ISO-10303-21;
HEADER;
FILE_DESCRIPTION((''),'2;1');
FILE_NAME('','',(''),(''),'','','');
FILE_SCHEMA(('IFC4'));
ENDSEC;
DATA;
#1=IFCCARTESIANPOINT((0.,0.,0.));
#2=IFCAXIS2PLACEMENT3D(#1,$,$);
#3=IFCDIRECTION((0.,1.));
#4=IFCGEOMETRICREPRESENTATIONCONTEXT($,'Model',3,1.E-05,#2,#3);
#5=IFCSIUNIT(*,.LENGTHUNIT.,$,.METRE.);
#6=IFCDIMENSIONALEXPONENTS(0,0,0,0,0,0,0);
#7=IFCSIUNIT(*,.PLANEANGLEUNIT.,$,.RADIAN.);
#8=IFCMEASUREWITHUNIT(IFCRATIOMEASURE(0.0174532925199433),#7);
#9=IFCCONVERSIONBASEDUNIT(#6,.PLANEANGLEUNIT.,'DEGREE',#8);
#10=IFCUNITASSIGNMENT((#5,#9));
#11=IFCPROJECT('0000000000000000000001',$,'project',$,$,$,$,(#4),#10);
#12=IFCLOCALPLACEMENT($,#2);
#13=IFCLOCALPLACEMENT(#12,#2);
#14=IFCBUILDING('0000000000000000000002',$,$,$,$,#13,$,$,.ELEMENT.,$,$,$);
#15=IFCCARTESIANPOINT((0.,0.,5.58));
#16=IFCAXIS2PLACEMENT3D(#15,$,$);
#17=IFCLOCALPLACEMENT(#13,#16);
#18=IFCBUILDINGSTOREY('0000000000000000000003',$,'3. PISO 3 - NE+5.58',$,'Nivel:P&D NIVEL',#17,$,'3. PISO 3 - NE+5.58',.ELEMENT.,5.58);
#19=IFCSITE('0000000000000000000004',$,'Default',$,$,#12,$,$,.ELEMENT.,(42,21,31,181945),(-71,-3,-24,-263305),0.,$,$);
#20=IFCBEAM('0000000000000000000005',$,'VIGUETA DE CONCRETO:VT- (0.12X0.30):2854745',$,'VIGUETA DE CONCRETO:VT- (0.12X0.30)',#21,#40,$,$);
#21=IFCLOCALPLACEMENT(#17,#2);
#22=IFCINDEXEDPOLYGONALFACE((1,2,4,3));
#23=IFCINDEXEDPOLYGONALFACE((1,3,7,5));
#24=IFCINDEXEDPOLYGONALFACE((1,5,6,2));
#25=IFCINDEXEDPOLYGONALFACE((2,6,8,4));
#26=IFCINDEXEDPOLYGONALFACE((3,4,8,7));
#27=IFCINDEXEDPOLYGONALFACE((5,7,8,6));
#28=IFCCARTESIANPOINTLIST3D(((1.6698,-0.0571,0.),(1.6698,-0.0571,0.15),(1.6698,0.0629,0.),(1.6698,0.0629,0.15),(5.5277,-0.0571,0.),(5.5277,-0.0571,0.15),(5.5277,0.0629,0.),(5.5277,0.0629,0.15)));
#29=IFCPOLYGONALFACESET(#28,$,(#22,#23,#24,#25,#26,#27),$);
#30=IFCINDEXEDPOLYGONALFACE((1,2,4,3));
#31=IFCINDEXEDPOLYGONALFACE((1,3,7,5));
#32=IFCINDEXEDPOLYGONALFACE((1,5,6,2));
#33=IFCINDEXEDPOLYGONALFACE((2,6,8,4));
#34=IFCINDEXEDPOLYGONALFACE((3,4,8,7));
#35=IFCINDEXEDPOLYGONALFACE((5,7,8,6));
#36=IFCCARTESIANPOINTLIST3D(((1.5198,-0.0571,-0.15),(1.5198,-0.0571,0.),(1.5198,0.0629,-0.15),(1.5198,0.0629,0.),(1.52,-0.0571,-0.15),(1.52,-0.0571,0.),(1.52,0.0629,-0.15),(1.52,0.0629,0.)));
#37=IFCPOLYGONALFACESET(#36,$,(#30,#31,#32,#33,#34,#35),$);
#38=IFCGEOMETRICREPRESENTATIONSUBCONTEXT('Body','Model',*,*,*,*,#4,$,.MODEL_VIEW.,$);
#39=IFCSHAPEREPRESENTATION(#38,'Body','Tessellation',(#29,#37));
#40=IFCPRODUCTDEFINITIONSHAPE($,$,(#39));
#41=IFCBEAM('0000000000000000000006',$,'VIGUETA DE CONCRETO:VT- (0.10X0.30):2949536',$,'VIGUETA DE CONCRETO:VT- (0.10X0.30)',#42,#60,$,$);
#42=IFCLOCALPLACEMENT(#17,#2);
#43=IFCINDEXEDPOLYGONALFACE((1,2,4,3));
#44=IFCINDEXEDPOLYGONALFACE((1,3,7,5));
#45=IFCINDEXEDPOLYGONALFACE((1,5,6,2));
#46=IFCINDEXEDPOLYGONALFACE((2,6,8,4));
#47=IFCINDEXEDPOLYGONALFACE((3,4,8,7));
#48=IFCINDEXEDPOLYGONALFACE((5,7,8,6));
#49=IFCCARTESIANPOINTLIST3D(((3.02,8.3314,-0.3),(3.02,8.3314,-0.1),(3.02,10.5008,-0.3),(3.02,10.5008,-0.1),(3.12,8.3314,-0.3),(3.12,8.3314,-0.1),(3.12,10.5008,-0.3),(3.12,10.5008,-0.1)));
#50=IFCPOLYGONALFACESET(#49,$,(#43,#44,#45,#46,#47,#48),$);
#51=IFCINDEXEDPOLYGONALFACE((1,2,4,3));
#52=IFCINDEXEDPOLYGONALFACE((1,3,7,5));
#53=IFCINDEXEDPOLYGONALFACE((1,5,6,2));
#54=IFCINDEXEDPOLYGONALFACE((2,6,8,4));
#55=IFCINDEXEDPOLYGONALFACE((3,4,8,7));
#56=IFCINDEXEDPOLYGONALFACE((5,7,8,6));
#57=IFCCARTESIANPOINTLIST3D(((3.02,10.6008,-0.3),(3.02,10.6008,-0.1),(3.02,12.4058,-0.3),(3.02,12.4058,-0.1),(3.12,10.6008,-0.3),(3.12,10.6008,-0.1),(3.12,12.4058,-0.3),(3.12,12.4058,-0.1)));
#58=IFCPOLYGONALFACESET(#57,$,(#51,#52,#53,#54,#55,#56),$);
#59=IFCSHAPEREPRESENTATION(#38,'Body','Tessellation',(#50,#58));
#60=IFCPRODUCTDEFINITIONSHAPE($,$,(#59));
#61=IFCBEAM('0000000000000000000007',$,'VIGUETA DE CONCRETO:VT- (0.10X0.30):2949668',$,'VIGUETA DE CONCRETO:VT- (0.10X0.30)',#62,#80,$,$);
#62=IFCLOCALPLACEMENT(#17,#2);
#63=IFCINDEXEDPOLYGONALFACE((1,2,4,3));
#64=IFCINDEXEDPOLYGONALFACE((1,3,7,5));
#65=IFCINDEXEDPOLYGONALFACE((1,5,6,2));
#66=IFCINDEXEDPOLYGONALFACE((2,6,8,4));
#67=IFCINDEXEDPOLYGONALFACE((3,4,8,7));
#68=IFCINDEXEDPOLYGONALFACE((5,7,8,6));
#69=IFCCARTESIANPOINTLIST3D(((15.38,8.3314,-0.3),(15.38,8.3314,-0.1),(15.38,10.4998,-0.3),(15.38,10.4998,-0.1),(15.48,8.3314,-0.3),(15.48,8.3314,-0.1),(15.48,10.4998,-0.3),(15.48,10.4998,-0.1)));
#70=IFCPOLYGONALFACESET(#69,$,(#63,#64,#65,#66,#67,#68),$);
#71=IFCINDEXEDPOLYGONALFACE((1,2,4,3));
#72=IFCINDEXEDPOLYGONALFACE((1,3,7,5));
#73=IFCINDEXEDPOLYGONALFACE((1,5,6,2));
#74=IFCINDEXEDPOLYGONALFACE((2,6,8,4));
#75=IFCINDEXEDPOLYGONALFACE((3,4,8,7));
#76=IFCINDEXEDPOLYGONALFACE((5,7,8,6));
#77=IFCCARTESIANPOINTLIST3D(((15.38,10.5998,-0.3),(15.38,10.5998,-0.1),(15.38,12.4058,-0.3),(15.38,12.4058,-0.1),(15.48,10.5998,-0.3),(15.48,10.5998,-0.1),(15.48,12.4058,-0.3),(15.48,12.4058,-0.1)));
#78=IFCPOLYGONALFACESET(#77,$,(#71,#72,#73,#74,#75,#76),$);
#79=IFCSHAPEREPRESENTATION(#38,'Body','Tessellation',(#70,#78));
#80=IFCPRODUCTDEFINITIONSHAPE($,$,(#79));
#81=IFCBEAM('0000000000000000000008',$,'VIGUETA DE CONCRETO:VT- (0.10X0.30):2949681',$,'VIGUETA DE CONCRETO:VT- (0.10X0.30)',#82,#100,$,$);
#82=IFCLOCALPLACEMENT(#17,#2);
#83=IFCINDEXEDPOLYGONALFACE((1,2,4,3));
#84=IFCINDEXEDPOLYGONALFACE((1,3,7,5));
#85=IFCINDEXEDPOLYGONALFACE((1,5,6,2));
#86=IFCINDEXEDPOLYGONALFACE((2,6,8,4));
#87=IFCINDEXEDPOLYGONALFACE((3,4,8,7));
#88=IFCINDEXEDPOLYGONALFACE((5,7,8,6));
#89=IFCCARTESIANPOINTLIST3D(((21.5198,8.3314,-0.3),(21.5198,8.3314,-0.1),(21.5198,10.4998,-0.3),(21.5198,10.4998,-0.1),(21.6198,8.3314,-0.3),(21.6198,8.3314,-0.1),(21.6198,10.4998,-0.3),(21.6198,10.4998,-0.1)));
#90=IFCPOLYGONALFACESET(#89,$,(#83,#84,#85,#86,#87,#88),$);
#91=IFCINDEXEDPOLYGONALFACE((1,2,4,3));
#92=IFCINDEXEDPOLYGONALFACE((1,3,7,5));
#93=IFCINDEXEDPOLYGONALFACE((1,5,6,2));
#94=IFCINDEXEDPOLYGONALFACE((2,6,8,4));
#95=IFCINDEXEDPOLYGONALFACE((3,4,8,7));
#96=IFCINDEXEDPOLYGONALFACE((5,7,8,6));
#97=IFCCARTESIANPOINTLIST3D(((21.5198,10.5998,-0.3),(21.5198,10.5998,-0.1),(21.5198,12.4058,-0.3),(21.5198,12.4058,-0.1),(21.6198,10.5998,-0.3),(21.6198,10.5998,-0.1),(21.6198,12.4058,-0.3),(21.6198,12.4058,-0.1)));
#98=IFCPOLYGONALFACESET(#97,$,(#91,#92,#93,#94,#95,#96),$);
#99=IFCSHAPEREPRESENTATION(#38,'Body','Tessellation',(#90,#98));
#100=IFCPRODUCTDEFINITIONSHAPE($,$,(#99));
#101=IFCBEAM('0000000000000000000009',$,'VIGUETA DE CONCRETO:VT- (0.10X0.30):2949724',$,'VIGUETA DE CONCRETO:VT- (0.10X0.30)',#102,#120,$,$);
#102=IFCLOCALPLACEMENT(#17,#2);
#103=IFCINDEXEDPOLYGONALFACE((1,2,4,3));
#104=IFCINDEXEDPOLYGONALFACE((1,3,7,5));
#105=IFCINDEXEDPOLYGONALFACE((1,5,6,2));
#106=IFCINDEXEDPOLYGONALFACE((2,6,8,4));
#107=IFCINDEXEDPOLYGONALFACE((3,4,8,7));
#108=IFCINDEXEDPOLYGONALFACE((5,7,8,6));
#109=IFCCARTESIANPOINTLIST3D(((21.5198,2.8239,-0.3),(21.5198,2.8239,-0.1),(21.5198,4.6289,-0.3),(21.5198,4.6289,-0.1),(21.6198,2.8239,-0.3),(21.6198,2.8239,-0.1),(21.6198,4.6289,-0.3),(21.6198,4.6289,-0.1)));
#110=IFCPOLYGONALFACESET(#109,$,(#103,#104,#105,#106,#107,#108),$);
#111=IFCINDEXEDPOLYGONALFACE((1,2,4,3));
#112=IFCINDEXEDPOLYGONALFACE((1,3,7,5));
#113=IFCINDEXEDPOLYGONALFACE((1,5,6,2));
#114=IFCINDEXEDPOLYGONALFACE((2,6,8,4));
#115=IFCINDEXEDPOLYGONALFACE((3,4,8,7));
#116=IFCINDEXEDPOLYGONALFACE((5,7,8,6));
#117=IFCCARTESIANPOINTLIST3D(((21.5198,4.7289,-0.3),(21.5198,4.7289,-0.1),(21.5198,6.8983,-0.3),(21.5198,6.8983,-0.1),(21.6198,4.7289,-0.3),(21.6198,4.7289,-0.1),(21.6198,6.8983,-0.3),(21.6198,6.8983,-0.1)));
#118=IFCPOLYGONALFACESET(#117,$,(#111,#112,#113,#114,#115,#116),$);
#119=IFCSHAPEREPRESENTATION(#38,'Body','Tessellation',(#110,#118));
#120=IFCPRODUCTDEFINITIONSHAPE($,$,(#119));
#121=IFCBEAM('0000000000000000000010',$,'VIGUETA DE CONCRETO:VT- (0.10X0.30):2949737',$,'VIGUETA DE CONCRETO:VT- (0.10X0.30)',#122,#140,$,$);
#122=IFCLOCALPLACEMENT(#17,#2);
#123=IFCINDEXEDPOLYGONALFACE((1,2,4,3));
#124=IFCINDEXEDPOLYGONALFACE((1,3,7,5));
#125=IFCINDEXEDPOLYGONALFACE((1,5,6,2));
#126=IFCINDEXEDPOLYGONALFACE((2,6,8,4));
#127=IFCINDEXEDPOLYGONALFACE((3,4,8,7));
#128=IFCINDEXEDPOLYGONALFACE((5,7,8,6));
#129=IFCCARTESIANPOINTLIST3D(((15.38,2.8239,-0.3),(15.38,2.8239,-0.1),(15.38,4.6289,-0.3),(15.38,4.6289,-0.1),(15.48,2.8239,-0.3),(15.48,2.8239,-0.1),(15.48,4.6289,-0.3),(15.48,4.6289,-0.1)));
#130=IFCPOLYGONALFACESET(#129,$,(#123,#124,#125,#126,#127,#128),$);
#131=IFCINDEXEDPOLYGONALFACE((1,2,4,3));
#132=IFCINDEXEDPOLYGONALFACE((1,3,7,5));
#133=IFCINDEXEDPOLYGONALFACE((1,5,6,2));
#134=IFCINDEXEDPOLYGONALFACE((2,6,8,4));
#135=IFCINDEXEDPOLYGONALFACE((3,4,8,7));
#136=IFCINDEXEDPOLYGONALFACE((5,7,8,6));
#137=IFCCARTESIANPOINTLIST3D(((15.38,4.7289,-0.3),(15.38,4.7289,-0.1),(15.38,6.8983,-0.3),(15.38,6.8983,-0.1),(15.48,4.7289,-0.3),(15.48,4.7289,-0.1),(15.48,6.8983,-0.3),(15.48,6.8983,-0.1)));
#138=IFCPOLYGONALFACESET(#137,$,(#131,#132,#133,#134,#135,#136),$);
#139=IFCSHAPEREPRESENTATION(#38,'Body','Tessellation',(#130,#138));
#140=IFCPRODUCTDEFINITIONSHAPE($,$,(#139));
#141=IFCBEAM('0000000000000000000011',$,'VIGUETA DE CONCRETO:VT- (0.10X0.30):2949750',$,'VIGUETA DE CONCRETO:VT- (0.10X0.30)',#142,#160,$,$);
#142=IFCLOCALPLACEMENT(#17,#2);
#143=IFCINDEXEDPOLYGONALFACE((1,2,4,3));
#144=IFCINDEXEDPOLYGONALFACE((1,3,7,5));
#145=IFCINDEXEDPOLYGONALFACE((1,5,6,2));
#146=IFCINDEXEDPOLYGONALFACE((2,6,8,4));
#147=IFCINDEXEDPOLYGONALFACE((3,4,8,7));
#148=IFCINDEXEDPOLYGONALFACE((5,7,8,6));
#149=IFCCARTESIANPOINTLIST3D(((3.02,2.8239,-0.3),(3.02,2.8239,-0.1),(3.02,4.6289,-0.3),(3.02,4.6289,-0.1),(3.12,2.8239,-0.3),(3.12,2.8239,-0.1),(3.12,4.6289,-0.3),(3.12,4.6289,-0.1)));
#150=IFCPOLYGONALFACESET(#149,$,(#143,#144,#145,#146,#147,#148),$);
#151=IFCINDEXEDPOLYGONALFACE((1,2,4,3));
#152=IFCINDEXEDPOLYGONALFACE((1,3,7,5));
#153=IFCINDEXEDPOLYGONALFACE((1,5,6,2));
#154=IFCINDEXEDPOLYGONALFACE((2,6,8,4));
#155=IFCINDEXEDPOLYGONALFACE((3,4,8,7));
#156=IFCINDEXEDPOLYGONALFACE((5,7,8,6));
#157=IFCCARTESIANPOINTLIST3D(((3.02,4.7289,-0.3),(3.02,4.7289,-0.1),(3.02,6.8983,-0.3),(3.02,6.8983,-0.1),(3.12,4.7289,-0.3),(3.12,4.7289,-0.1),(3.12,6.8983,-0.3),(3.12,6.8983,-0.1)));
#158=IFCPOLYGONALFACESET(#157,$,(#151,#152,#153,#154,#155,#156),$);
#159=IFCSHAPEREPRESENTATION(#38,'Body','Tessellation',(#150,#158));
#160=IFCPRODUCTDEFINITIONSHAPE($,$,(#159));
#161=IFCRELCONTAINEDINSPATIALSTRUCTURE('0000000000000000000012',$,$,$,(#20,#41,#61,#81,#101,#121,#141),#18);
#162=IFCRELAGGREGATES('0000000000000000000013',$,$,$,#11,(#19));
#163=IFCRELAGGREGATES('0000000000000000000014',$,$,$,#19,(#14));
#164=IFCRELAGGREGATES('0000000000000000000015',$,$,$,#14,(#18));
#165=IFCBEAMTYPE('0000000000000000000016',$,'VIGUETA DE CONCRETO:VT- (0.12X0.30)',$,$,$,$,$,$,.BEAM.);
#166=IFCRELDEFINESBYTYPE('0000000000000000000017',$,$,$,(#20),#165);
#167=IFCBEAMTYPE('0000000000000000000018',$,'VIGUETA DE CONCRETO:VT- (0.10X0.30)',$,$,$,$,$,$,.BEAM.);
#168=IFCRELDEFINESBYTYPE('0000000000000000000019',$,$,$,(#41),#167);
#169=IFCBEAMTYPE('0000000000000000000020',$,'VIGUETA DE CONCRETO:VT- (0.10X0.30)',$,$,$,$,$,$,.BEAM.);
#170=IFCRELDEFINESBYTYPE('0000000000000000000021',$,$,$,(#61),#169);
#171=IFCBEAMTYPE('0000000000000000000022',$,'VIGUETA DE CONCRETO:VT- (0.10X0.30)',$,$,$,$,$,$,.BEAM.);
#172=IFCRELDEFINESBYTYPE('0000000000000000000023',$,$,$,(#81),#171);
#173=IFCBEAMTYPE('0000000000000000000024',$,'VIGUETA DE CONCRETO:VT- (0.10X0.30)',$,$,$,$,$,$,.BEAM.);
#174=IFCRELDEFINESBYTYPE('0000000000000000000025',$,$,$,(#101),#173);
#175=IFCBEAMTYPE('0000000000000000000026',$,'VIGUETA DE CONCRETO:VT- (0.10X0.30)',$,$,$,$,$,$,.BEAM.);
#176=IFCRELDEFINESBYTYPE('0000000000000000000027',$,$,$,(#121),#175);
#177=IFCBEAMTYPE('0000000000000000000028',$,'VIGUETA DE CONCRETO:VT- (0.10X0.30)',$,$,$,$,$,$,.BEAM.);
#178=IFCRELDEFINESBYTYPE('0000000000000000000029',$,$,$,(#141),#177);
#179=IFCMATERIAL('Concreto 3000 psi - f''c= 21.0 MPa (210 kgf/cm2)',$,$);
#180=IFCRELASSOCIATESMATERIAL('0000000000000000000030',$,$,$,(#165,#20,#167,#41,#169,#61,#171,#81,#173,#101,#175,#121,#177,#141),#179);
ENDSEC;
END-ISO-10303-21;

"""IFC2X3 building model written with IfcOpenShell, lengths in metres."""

from ifc_helpers import new_model, entity, si_unit, converted_unit, direction, frame, frame_2d, origin, place, context, subcontext, project, spatial, rectangle, extrude, source, transform, mapped, material, type_object, type_shapes, element, save


model = new_model("IFC2X3")

# Units and contexts
model_context = context("Model", 3, precision=1e-05, world=origin(), true_north=direction((0.0, 1.0)))
body_context = subcontext(model_context, "Body", "Model", "MODEL_VIEW")
ifc_project = project(units=[si_unit("LENGTHUNIT", "METRE"), converted_unit("PLANEANGLEUNIT", "DEGREE", entity("IfcRatioMeasure", 0.0174532925199433), si_unit("PLANEANGLEUNIT", "RADIAN"), dimensions=[0, 0, 0, 0, 0, 0, 0])], contexts=[model_context])

# Site, building, storey
site_placement = place(None, origin())
site = spatial("IfcSite", under=ifc_project, at=site_placement, Name="Default", CompositionType="ELEMENT", RefLatitude=(42, 21, 31, 181945), RefLongitude=(-71, -3, -24, -263305), RefElevation=0.0)
building_placement = place(site_placement, origin())
building = spatial("IfcBuilding", under=site, at=building_placement, CompositionType="ELEMENT")
storey_placement = place(building_placement, frame((0.0, 0.0, 5.58)))
storey = spatial("IfcBuildingStorey", under=building, at=storey_placement, Name="3. PISO 3 - NE+5.58", ObjectType="Nivel:P&D NIVEL", LongName="3. PISO 3 - NE+5.58", CompositionType="ELEMENT", Elevation=5.58)

# Beams
ifc_material = material(Name="Concreto 3000 psi - f'c= 21.0 MPa (210 kgf/cm2)")
beam_type_1 = type_object("IfcBeamType", Name="VIGUETA DE CONCRETO:VT- (0.12X0.30)", PredefinedType="BEAM", material=ifc_material)
shared_shape_1 = source(origin(), body_context, "Body", "SweptSolid", [
    extrude(rectangle(XDim=0.15, YDim=0.12, at=frame_2d((0.0, 0.0), x_axis=(1.0, 0.0))), frame((1.6698, 0.0029, 5.655), z_axis=(1.0, 0.0, 0.0), x_axis=(0.0, 0.0, -1.0)), (0.0, 0.0, 1.0), 3.8579),
    extrude(rectangle(XDim=0.15, YDim=0.12, at=frame_2d((0.0, 0.0), x_axis=(1.0, 0.0))), frame((1.5198, 0.0029, 5.505), z_axis=(1.0, 0.0, 0.0), x_axis=(0.0, 0.0, -1.0)), (0.0, 0.0, 1.0), 0.0002),
])
type_shapes(beam_type_1, [shared_shape_1])
beam_1_placement = place(storey_placement, frame((0.0, 0.0, -5.58)))
element("IfcBeam", 1, at=beam_1_placement, inside=storey, type_object=beam_type_1, material=ifc_material, Name="VIGUETA DE CONCRETO:VT- (0.12X0.30):2854745", ObjectType="VIGUETA DE CONCRETO:VT- (0.12X0.30)", context=body_context, shape_type="MappedRepresentation", body=[
    mapped(shared_shape_1, transform((0.0, 0.0, 0.0), scale=1.0)),
])
beam_type_2 = type_object("IfcBeamType", Name="VIGUETA DE CONCRETO:VT- (0.10X0.30)", PredefinedType="BEAM", material=ifc_material)
shared_shape_2 = source(origin(), body_context, "Body", "SweptSolid", [
    extrude(rectangle(XDim=0.2, YDim=0.1, at=frame_2d((0.0, 0.0), x_axis=(0.0, 1.0))), frame((3.07, 10.5008, 5.38), z_axis=(0.0, -1.0, 0.0), x_axis=(-1.0, 0.0, 0.0)), (0.0, 0.0, 1.0), 2.1694),
    extrude(rectangle(XDim=0.2, YDim=0.1, at=frame_2d((0.0, 0.0), x_axis=(0.0, 1.0))), frame((3.07, 12.4058, 5.38), z_axis=(0.0, -1.0, 0.0), x_axis=(-1.0, 0.0, 0.0)), (0.0, 0.0, 1.0), 1.805),
])
type_shapes(beam_type_2, [shared_shape_2])
beam_2_placement = place(storey_placement, frame((0.0, 0.0, -5.58)))
element("IfcBeam", 2, at=beam_2_placement, inside=storey, type_object=beam_type_2, material=ifc_material, Name="VIGUETA DE CONCRETO:VT- (0.10X0.30):2949536", ObjectType="VIGUETA DE CONCRETO:VT- (0.10X0.30)", context=body_context, shape_type="MappedRepresentation", body=[
    mapped(shared_shape_2, transform((0.0, 0.0, 0.0), scale=1.0)),
])
beam_type_3 = type_object("IfcBeamType", Name="VIGUETA DE CONCRETO:VT- (0.10X0.30)", PredefinedType="BEAM", material=ifc_material)
shared_shape_3 = source(origin(), body_context, "Body", "SweptSolid", [
    extrude(rectangle(XDim=0.2, YDim=0.1, at=frame_2d((0.0, 0.0), x_axis=(0.0, 1.0))), frame((15.43, 10.4998, 5.38), z_axis=(0.0, -1.0, 0.0), x_axis=(-1.0, 0.0, 0.0)), (0.0, 0.0, 1.0), 2.1684),
    extrude(rectangle(XDim=0.2, YDim=0.1, at=frame_2d((0.0, 0.0), x_axis=(0.0, 1.0))), frame((15.43, 12.4058, 5.38), z_axis=(0.0, -1.0, 0.0), x_axis=(-1.0, 0.0, 0.0)), (0.0, 0.0, 1.0), 1.806),
])
type_shapes(beam_type_3, [shared_shape_3])
beam_3_placement = place(storey_placement, frame((0.0, 0.0, -5.58)))
element("IfcBeam", 3, at=beam_3_placement, inside=storey, type_object=beam_type_3, material=ifc_material, Name="VIGUETA DE CONCRETO:VT- (0.10X0.30):2949668", ObjectType="VIGUETA DE CONCRETO:VT- (0.10X0.30)", context=body_context, shape_type="MappedRepresentation", body=[
    mapped(shared_shape_3, transform((0.0, 0.0, 0.0), scale=1.0)),
])
beam_type_4 = type_object("IfcBeamType", Name="VIGUETA DE CONCRETO:VT- (0.10X0.30)", PredefinedType="BEAM", material=ifc_material)
shared_shape_4 = source(origin(), body_context, "Body", "SweptSolid", [
    extrude(rectangle(XDim=0.2, YDim=0.1, at=frame_2d((0.0, 0.0), x_axis=(0.0, 1.0))), frame((21.5698, 10.4998, 5.38), z_axis=(0.0, -1.0, 0.0), x_axis=(-1.0, 0.0, 0.0)), (0.0, 0.0, 1.0), 2.1684),
    extrude(rectangle(XDim=0.2, YDim=0.1, at=frame_2d((0.0, 0.0), x_axis=(0.0, 1.0))), frame((21.5698, 12.4058, 5.38), z_axis=(0.0, -1.0, 0.0), x_axis=(-1.0, 0.0, 0.0)), (0.0, 0.0, 1.0), 1.806),
])
type_shapes(beam_type_4, [shared_shape_4])
beam_4_placement = place(storey_placement, frame((0.0, 0.0, -5.58)))
element("IfcBeam", 4, at=beam_4_placement, inside=storey, type_object=beam_type_4, material=ifc_material, Name="VIGUETA DE CONCRETO:VT- (0.10X0.30):2949681", ObjectType="VIGUETA DE CONCRETO:VT- (0.10X0.30)", context=body_context, shape_type="MappedRepresentation", body=[
    mapped(shared_shape_4, transform((0.0, 0.0, 0.0), scale=1.0)),
])
beam_type_5 = type_object("IfcBeamType", Name="VIGUETA DE CONCRETO:VT- (0.10X0.30)", PredefinedType="BEAM", material=ifc_material)
shared_shape_5 = source(origin(), body_context, "Body", "SweptSolid", [
    extrude(rectangle(XDim=0.2, YDim=0.1, at=frame_2d((0.0, 0.0), x_axis=(0.0, 1.0))), frame((21.5698, 4.6289, 5.38), z_axis=(0.0, -1.0, 0.0), x_axis=(-1.0, 0.0, 0.0)), (0.0, 0.0, 1.0), 1.805),
    extrude(rectangle(XDim=0.2, YDim=0.1, at=frame_2d((0.0, 0.0), x_axis=(0.0, 1.0))), frame((21.5698, 6.8983, 5.38), z_axis=(0.0, -1.0, 0.0), x_axis=(-1.0, 0.0, 0.0)), (0.0, 0.0, 1.0), 2.1694),
])
type_shapes(beam_type_5, [shared_shape_5])
beam_5_placement = place(storey_placement, frame((0.0, 0.0, -5.58)))
element("IfcBeam", 5, at=beam_5_placement, inside=storey, type_object=beam_type_5, material=ifc_material, Name="VIGUETA DE CONCRETO:VT- (0.10X0.30):2949724", ObjectType="VIGUETA DE CONCRETO:VT- (0.10X0.30)", context=body_context, shape_type="MappedRepresentation", body=[
    mapped(shared_shape_5, transform((0.0, 0.0, 0.0), scale=1.0)),
])
beam_type_6 = type_object("IfcBeamType", Name="VIGUETA DE CONCRETO:VT- (0.10X0.30)", PredefinedType="BEAM", material=ifc_material)
shared_shape_6 = source(origin(), body_context, "Body", "SweptSolid", [
    extrude(rectangle(XDim=0.2, YDim=0.1, at=frame_2d((0.0, 0.0), x_axis=(0.0, 1.0))), frame((15.43, 4.6289, 5.38), z_axis=(0.0, -1.0, 0.0), x_axis=(-1.0, 0.0, 0.0)), (0.0, 0.0, 1.0), 1.805),
    extrude(rectangle(XDim=0.2, YDim=0.1, at=frame_2d((0.0, 0.0), x_axis=(0.0, 1.0))), frame((15.43, 6.8983, 5.38), z_axis=(0.0, -1.0, 0.0), x_axis=(-1.0, 0.0, 0.0)), (0.0, 0.0, 1.0), 2.1694),
])
type_shapes(beam_type_6, [shared_shape_6])
beam_6_placement = place(storey_placement, frame((0.0, 0.0, -5.58)))
element("IfcBeam", 6, at=beam_6_placement, inside=storey, type_object=beam_type_6, material=ifc_material, Name="VIGUETA DE CONCRETO:VT- (0.10X0.30):2949737", ObjectType="VIGUETA DE CONCRETO:VT- (0.10X0.30)", context=body_context, shape_type="MappedRepresentation", body=[
    mapped(shared_shape_6, transform((0.0, 0.0, 0.0), scale=1.0)),
])
beam_type_7 = type_object("IfcBeamType", Name="VIGUETA DE CONCRETO:VT- (0.10X0.30)", PredefinedType="BEAM", material=ifc_material)
shared_shape_7 = source(origin(), body_context, "Body", "SweptSolid", [
    extrude(rectangle(XDim=0.2, YDim=0.1, at=frame_2d((0.0, 0.0), x_axis=(0.0, 1.0))), frame((3.07, 4.6289, 5.38), z_axis=(0.0, -1.0, 0.0), x_axis=(-1.0, 0.0, 0.0)), (0.0, 0.0, 1.0), 1.805),
    extrude(rectangle(XDim=0.2, YDim=0.1, at=frame_2d((0.0, 0.0), x_axis=(0.0, 1.0))), frame((3.07, 6.8983, 5.38), z_axis=(0.0, -1.0, 0.0), x_axis=(-1.0, 0.0, 0.0)), (0.0, 0.0, 1.0), 2.1694),
])
type_shapes(beam_type_7, [shared_shape_7])
beam_7_placement = place(storey_placement, frame((0.0, 0.0, -5.58)))
element("IfcBeam", 7, at=beam_7_placement, inside=storey, type_object=beam_type_7, material=ifc_material, Name="VIGUETA DE CONCRETO:VT- (0.10X0.30):2949750", ObjectType="VIGUETA DE CONCRETO:VT- (0.10X0.30)", context=body_context, shape_type="MappedRepresentation", body=[
    mapped(shared_shape_7, transform((0.0, 0.0, 0.0), scale=1.0)),
])

save(model, "model.ifc")
